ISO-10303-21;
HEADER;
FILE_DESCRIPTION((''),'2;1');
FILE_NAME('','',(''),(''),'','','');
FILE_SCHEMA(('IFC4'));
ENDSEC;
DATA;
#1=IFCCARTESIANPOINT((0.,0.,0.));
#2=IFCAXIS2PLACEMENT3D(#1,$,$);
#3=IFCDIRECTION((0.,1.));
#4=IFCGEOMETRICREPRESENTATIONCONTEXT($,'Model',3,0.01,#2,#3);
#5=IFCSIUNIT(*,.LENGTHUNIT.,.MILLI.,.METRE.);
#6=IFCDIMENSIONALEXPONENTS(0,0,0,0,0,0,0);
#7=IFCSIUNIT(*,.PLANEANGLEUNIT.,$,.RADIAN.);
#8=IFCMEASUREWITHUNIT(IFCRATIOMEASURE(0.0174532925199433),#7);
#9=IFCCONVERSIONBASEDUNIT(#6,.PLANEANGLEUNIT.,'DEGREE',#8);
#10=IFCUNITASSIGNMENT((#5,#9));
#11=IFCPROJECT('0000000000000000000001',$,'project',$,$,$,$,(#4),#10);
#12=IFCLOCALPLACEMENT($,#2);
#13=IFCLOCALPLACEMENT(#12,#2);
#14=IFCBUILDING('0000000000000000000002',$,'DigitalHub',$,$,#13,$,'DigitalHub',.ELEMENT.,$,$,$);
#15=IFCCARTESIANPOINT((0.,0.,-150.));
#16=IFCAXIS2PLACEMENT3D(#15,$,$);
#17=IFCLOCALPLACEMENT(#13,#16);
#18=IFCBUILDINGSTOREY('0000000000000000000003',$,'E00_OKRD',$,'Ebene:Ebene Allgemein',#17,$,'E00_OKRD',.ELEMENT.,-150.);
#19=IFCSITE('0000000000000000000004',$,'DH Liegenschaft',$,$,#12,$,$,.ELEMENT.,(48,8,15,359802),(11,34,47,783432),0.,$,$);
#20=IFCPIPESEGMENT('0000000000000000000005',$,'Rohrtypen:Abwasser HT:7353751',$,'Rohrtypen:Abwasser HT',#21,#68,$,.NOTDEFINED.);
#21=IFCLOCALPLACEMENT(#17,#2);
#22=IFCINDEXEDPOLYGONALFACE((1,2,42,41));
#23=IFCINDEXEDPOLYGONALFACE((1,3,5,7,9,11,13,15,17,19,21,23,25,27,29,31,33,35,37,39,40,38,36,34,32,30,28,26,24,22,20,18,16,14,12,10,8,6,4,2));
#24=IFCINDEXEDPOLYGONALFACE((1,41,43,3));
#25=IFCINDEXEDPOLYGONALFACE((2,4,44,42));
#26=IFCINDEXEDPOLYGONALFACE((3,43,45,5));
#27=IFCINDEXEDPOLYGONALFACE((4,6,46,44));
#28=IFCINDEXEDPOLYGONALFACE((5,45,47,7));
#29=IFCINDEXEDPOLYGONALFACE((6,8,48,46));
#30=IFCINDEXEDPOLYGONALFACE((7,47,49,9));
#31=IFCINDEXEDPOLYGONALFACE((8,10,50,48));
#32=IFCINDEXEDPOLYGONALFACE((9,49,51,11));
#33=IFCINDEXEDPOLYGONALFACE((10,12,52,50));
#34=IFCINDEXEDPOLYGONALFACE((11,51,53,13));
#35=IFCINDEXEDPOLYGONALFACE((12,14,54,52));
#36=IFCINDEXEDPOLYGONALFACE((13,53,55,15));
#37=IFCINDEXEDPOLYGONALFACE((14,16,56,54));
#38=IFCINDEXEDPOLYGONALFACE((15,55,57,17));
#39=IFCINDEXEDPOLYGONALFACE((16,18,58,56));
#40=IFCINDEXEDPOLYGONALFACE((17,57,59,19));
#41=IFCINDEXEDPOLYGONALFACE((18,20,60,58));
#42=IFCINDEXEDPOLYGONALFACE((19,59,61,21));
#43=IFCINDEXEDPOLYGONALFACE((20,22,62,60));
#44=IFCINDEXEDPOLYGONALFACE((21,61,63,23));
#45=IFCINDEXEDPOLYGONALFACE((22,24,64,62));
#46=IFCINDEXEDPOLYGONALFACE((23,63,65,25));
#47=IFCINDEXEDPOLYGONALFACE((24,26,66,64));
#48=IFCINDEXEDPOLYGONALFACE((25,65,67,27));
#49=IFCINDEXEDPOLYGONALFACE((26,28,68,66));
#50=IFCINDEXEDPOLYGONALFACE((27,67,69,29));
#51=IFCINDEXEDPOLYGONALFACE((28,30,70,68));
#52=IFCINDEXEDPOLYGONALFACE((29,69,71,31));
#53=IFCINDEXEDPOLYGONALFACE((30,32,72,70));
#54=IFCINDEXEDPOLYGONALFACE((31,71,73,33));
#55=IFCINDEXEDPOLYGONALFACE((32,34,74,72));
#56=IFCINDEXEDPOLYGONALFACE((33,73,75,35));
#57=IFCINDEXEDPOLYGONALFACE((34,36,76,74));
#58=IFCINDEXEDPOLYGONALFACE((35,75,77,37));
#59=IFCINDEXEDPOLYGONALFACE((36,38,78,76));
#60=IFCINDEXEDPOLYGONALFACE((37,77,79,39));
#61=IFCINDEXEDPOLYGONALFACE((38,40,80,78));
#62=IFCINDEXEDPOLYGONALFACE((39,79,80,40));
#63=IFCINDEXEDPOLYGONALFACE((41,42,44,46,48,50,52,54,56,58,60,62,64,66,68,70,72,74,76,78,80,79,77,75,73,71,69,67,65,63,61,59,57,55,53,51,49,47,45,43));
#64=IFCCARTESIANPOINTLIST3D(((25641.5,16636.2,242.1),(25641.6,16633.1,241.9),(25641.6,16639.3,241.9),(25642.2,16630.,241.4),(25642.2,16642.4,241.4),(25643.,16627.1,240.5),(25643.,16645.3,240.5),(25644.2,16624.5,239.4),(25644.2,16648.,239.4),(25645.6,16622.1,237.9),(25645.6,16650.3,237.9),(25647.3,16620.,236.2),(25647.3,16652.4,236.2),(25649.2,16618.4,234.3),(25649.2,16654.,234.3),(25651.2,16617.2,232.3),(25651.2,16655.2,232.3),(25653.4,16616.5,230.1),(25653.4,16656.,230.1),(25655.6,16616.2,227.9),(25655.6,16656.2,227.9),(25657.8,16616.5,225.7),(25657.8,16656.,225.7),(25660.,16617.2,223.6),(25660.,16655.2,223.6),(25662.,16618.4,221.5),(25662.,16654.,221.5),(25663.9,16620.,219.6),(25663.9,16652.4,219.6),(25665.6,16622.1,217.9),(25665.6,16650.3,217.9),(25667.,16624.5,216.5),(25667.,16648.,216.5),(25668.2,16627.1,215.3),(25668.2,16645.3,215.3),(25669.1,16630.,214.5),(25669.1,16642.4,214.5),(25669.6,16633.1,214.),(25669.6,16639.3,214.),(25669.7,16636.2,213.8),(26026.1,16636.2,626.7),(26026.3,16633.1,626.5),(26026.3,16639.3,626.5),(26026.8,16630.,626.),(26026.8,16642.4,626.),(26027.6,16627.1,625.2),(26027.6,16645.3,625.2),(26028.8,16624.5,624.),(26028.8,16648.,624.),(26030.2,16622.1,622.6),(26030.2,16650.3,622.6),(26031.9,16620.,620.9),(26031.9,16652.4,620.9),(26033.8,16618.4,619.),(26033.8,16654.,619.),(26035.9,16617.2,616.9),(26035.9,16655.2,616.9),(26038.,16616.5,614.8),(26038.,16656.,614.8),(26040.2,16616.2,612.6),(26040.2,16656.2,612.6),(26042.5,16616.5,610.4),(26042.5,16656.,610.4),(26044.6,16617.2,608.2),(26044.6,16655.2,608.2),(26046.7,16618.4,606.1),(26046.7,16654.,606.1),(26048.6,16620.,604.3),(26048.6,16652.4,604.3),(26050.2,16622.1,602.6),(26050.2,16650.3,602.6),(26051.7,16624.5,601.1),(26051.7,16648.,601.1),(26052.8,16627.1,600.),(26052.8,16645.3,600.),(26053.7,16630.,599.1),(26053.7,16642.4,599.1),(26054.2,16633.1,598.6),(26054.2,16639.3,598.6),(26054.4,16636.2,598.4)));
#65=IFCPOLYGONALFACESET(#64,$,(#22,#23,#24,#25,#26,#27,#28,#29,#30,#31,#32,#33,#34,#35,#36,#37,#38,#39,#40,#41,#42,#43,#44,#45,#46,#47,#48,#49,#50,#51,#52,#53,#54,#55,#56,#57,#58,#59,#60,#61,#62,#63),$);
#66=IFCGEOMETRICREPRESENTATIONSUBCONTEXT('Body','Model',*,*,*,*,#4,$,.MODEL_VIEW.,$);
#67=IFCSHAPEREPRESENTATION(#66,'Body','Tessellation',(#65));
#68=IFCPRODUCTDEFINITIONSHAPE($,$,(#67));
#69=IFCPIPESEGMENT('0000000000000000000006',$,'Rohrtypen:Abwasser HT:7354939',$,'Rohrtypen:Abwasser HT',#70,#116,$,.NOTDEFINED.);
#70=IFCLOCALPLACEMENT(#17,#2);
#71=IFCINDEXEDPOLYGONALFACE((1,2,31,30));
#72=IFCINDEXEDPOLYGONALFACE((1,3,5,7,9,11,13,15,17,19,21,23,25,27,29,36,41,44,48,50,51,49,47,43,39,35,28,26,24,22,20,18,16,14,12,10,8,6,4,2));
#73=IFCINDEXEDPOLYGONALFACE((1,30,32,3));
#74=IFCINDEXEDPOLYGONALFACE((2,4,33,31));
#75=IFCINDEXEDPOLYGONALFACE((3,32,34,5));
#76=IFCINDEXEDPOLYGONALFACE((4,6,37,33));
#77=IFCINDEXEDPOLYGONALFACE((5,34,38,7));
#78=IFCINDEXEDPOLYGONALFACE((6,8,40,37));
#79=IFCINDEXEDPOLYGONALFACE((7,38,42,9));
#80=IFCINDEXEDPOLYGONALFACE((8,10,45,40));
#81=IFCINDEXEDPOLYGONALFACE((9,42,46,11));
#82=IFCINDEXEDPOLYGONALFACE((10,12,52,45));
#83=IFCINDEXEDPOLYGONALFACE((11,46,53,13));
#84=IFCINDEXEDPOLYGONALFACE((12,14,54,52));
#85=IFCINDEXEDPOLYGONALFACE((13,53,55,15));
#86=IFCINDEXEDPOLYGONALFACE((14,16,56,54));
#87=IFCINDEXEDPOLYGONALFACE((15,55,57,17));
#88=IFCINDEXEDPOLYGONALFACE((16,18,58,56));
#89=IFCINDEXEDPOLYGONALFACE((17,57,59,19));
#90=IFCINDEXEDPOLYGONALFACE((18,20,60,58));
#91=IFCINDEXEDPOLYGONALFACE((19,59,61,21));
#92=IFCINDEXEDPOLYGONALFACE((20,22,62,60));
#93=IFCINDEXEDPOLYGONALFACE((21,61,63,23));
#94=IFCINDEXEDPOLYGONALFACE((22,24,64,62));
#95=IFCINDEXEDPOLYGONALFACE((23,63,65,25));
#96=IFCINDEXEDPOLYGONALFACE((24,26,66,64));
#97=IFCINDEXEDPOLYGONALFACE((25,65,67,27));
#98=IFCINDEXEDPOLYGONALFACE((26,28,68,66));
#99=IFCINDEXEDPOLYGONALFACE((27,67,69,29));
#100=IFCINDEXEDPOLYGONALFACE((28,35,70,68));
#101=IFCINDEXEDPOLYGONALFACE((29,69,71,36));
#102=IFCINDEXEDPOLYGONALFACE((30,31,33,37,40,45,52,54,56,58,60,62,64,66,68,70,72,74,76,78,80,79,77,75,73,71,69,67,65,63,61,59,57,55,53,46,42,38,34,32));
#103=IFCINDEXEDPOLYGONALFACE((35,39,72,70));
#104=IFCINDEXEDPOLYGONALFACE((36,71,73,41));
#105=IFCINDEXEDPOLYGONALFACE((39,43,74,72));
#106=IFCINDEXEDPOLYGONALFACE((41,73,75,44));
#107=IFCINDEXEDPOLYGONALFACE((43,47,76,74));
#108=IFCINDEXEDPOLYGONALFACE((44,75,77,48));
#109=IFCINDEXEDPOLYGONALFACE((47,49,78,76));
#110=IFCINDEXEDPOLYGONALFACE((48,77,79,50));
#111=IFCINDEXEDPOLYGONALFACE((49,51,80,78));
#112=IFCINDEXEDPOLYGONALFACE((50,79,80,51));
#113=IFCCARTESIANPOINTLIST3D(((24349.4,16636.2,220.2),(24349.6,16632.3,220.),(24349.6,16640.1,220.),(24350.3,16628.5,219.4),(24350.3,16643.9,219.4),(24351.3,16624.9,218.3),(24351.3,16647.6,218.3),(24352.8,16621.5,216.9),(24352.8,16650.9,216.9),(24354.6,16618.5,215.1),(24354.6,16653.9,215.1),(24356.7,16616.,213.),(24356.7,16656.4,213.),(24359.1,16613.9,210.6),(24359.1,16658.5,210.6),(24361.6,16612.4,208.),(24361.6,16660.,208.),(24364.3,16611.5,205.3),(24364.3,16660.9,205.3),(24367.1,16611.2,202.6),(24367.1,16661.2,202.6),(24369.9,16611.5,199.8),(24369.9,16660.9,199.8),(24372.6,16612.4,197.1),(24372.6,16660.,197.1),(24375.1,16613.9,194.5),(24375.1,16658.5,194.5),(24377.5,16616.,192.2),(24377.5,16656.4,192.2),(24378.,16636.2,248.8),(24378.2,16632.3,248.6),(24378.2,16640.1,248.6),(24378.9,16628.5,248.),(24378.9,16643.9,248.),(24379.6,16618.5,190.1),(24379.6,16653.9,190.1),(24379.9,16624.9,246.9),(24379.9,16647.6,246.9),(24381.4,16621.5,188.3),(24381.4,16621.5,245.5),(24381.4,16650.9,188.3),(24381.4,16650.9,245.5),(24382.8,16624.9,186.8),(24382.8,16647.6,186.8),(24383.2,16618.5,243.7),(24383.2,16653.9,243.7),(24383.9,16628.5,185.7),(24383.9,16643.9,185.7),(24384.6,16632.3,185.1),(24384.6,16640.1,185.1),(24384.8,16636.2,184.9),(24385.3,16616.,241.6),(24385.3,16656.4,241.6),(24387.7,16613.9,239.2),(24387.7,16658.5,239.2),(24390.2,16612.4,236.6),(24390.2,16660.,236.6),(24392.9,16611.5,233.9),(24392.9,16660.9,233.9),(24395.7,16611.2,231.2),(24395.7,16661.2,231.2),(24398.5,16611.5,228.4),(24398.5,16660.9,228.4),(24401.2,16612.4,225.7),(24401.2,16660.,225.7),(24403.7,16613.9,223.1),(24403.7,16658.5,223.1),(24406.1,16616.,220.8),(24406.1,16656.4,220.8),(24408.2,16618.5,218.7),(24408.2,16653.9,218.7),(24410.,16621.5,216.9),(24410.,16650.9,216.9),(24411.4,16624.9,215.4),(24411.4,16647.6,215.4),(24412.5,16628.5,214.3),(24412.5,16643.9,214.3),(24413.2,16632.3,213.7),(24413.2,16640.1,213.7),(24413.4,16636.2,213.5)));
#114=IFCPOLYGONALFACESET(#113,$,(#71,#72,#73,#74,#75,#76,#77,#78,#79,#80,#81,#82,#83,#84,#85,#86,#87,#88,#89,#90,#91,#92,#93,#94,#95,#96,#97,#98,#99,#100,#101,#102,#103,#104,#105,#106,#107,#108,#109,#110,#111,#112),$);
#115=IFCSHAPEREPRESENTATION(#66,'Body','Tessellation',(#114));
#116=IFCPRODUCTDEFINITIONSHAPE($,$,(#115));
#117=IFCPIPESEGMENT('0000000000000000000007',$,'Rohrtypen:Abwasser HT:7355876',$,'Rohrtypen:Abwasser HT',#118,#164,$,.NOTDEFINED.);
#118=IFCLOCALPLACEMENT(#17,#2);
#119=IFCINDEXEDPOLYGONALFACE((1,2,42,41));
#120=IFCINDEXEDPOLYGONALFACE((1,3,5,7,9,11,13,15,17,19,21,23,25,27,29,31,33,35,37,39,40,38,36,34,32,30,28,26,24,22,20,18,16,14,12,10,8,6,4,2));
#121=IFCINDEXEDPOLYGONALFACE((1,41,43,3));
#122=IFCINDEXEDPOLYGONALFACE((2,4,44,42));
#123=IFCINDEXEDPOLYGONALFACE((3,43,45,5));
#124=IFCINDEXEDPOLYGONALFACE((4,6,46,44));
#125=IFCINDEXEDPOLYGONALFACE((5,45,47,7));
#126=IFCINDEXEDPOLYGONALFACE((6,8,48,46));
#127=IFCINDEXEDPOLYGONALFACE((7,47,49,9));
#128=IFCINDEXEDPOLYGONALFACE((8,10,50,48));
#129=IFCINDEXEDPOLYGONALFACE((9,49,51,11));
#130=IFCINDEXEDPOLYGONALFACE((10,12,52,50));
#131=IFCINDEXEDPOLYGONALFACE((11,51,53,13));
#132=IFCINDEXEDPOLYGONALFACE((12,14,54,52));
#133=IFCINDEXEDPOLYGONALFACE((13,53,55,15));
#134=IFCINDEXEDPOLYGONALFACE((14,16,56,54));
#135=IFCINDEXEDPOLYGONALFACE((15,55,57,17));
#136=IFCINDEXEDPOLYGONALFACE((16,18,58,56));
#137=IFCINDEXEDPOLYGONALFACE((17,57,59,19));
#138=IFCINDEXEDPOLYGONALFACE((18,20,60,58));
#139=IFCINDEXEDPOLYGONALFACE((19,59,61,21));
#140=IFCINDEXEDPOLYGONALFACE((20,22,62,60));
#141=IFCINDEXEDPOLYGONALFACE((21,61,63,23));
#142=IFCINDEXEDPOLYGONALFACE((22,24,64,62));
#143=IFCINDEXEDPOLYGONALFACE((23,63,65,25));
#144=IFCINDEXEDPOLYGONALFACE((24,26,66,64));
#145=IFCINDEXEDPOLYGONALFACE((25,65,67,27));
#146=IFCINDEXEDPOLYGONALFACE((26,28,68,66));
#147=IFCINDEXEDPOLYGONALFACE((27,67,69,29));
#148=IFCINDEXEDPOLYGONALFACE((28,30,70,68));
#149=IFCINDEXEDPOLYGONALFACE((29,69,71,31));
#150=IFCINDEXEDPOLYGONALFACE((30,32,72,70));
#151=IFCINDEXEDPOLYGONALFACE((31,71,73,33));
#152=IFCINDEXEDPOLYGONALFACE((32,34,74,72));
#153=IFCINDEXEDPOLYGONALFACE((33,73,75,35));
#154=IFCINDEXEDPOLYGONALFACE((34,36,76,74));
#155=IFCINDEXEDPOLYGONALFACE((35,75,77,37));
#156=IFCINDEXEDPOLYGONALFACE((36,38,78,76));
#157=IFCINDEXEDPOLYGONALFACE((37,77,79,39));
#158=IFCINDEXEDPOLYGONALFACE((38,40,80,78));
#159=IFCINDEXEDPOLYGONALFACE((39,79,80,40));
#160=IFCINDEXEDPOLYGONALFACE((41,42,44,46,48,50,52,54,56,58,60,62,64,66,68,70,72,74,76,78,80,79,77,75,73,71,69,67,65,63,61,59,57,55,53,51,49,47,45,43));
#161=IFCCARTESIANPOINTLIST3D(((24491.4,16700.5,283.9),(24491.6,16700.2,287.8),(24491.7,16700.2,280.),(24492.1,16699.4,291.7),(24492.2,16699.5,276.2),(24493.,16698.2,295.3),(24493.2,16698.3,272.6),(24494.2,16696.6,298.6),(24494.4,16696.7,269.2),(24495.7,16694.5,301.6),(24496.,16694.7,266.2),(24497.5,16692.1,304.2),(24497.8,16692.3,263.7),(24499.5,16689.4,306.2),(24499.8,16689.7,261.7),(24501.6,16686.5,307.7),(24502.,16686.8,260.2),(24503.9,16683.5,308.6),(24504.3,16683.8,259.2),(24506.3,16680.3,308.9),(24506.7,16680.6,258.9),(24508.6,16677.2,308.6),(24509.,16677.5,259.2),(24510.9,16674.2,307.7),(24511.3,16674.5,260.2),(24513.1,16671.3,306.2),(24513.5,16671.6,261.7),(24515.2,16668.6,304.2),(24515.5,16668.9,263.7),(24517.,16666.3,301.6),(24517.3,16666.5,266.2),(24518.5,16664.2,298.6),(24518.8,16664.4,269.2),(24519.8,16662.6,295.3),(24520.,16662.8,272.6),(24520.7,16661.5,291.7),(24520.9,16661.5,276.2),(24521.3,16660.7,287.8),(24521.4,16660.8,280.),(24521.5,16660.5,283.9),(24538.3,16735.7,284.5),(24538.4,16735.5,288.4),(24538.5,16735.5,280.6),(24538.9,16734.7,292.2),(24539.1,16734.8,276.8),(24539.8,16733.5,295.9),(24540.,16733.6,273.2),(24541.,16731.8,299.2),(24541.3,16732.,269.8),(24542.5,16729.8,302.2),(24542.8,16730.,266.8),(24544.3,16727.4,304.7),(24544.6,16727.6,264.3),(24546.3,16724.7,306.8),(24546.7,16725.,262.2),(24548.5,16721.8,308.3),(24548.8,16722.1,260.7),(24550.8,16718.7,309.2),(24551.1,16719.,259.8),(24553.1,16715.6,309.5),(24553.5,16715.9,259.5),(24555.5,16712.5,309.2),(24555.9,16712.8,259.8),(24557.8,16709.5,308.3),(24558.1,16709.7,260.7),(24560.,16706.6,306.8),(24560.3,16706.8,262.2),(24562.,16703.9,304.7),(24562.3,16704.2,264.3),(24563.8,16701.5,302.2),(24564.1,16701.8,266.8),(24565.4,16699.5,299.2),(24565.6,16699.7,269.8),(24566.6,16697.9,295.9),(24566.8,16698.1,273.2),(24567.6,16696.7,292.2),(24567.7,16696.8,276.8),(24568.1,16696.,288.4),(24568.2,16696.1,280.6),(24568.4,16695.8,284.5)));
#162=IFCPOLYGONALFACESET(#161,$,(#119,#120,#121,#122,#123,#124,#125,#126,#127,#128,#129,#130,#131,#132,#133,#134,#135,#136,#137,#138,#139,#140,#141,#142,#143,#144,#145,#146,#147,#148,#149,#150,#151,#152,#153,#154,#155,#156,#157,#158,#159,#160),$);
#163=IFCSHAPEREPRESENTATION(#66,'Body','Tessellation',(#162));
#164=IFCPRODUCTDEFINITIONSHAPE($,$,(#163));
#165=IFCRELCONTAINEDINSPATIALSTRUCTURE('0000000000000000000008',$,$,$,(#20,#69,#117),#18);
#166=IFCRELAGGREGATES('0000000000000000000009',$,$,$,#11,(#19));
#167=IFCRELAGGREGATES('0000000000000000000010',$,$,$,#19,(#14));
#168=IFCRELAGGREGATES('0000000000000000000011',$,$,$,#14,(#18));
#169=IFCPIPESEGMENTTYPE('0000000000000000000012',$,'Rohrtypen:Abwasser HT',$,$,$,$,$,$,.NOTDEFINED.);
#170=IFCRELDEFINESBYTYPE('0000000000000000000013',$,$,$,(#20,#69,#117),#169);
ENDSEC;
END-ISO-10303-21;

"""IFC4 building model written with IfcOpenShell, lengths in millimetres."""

from ifc_helpers import new_model, entity, si_unit, converted_unit, direction, frame, origin, place, context, subcontext, project, spatial, indexed_curve, outline, extrude, type_object, element, save


model = new_model("IFC4")

# Units and contexts
model_context = context("Model", 3, precision=0.01, world=origin(), true_north=direction((0.0, 1.0)))
body_context = subcontext(model_context, "Body", "Model", "MODEL_VIEW")
ifc_project = project(units=[si_unit("LENGTHUNIT", "METRE", prefix="MILLI"), converted_unit("PLANEANGLEUNIT", "DEGREE", entity("IfcRatioMeasure", 0.0174532925199433), si_unit("PLANEANGLEUNIT", "RADIAN"), dimensions=[0, 0, 0, 0, 0, 0, 0])], contexts=[model_context])

# Site, building, storey
site_placement = place(None, origin())
site = spatial("IfcSite", under=ifc_project, at=site_placement, Name="DH Liegenschaft", CompositionType="ELEMENT", RefLatitude=(48, 8, 15, 359802), RefLongitude=(11, 34, 47, 783432), RefElevation=0.0)
building_placement = place(site_placement, origin())
building = spatial("IfcBuilding", under=site, at=building_placement, Name="DigitalHub", LongName="DigitalHub", CompositionType="ELEMENT")
storey_placement = place(building_placement, frame((0.0, 0.0, -150.0)))
storey = spatial("IfcBuildingStorey", under=building, at=storey_placement, Name="E00_OKRD", ObjectType="Ebene:Ebene Allgemein", LongName="E00_OKRD", CompositionType="ELEMENT", Elevation=-150.0)

# Pipe segments
pipe_segment_type_1 = type_object("IfcPipeSegmentType", Name="Rohrtypen:Abwasser HT", PredefinedType="NOTDEFINED")
pipe_segment_1_placement = place(storey_placement, frame((25639.9, 16614.6, 212.2)))
element("IfcPipeSegment", 1, at=pipe_segment_1_placement, inside=storey, type_object=pipe_segment_type_1, Name="Rohrtypen:Abwasser HT:7353751", ObjectType="Rohrtypen:Abwasser HT", PredefinedType="NOTDEFINED", context=body_context, shape_type="SweptSolid", body=[
    extrude(outline(indexed_curve([(20.0, 0.0), (19.8, 3.1), (19.0, 6.2), (17.8, 9.1), (16.2, 11.8), (14.1, 14.1), (11.8, 16.2), (9.1, 17.8), (6.2, 19.0), (3.1, 19.8), (0.0, 20.0), (-3.1, 19.8), (-6.2, 19.0), (-9.1, 17.8), (-11.8, 16.2), (-14.1, 14.1), (-16.2, 11.8), (-17.8, 9.1), (-19.0, 6.2), (-19.8, 3.1), (-20.0, 0.0), (-19.8, -3.1), (-19.0, -6.2), (-17.8, -9.1), (-16.2, -11.8), (-14.1, -14.1), (-11.8, -16.2), (-9.1, -17.8), (-6.2, -19.0), (-3.1, -19.8), (0.0, -20.0), (3.1, -19.8), (6.2, -19.0), (9.1, -17.8), (11.8, -16.2), (14.1, -14.1), (16.2, -11.8), (17.8, -9.1), (19.0, -6.2), (19.8, -3.1), (20.0, 0.0)], self_intersect=False)), frame((15.7, 21.6, 15.7), z_axis=(0.707107, 0.0, 0.707107), x_axis=(0.0, 1.0, 0.0)), (0.0, 0.0, 1.0), 544.0),
])
pipe_segment_2_placement = place(storey_placement, frame((24347.8, 16609.6, 183.3)))
element("IfcPipeSegment", 2, at=pipe_segment_2_placement, inside=storey, type_object=pipe_segment_type_1, Name="Rohrtypen:Abwasser HT:7354939", ObjectType="Rohrtypen:Abwasser HT", PredefinedType="NOTDEFINED", context=body_context, shape_type="SweptSolid", body=[
    extrude(outline(indexed_curve([(25.0, 0.0), (24.7, 3.9), (23.8, 7.7), (22.3, 11.3), (20.2, 14.7), (17.7, 17.7), (14.7, 20.2), (11.3, 22.3), (7.7, 23.8), (3.9, 24.7), (0.0, 25.0), (-3.9, 24.7), (-7.7, 23.8), (-11.3, 22.3), (-14.7, 20.2), (-17.7, 17.7), (-20.2, 14.7), (-22.3, 11.3), (-23.8, 7.7), (-24.7, 3.9), (-25.0, 0.0), (-24.7, -3.9), (-23.8, -7.7), (-22.3, -11.3), (-20.2, -14.7), (-17.7, -17.7), (-14.7, -20.2), (-11.3, -22.3), (-7.7, -23.8), (-3.9, -24.7), (0.0, -25.0), (3.9, -24.7), (7.7, -23.8), (11.3, -22.3), (14.7, -20.2), (17.7, -17.7), (20.2, -14.7), (22.3, -11.3), (23.8, -7.7), (24.7, -3.9), (25.0, 0.0)], self_intersect=False)), frame((19.3, 26.6, 19.3), z_axis=(0.707107, 0.0, 0.707107), x_axis=(0.0, -1.0, 0.0)), (0.0, 0.0, 1.0), 40.4),
])
pipe_segment_3_placement = place(storey_placement, frame((24489.8, 16658.9, 257.3)))
element("IfcPipeSegment", 3, at=pipe_segment_3_placement, inside=storey, type_object=pipe_segment_type_1, Name="Rohrtypen:Abwasser HT:7355876", ObjectType="Rohrtypen:Abwasser HT", PredefinedType="NOTDEFINED", context=body_context, shape_type="SweptSolid", body=[
    extrude(outline(indexed_curve([(25.0, 0.0), (24.7, 3.9), (23.8, 7.7), (22.3, 11.3), (20.2, 14.7), (17.7, 17.7), (14.7, 20.2), (11.3, 22.3), (7.7, 23.8), (3.9, 24.7), (0.0, 25.0), (-3.9, 24.7), (-7.7, 23.8), (-11.3, 22.3), (-14.7, 20.2), (-17.7, 17.7), (-20.2, 14.7), (-22.3, 11.3), (-23.8, 7.7), (-24.7, 3.9), (-25.0, 0.0), (-24.7, -3.9), (-23.8, -7.7), (-22.3, -11.3), (-20.2, -14.7), (-17.7, -17.7), (-14.7, -20.2), (-11.3, -22.3), (-7.7, -23.8), (-3.9, -24.7), (0.0, -25.0), (3.9, -24.7), (7.7, -23.8), (11.3, -22.3), (14.7, -20.2), (17.7, -17.7), (20.2, -14.7), (22.3, -11.3), (23.8, -7.7), (24.7, -3.9), (25.0, 0.0)], self_intersect=False)), frame((16.6, 21.6, 26.6), z_axis=(0.798581, 0.601804, 0.01), x_axis=(0.601834, -0.798621, 0.0)), (0.0, 0.0, 1.0), 58.6),
])

save(model, "model.ifc")
